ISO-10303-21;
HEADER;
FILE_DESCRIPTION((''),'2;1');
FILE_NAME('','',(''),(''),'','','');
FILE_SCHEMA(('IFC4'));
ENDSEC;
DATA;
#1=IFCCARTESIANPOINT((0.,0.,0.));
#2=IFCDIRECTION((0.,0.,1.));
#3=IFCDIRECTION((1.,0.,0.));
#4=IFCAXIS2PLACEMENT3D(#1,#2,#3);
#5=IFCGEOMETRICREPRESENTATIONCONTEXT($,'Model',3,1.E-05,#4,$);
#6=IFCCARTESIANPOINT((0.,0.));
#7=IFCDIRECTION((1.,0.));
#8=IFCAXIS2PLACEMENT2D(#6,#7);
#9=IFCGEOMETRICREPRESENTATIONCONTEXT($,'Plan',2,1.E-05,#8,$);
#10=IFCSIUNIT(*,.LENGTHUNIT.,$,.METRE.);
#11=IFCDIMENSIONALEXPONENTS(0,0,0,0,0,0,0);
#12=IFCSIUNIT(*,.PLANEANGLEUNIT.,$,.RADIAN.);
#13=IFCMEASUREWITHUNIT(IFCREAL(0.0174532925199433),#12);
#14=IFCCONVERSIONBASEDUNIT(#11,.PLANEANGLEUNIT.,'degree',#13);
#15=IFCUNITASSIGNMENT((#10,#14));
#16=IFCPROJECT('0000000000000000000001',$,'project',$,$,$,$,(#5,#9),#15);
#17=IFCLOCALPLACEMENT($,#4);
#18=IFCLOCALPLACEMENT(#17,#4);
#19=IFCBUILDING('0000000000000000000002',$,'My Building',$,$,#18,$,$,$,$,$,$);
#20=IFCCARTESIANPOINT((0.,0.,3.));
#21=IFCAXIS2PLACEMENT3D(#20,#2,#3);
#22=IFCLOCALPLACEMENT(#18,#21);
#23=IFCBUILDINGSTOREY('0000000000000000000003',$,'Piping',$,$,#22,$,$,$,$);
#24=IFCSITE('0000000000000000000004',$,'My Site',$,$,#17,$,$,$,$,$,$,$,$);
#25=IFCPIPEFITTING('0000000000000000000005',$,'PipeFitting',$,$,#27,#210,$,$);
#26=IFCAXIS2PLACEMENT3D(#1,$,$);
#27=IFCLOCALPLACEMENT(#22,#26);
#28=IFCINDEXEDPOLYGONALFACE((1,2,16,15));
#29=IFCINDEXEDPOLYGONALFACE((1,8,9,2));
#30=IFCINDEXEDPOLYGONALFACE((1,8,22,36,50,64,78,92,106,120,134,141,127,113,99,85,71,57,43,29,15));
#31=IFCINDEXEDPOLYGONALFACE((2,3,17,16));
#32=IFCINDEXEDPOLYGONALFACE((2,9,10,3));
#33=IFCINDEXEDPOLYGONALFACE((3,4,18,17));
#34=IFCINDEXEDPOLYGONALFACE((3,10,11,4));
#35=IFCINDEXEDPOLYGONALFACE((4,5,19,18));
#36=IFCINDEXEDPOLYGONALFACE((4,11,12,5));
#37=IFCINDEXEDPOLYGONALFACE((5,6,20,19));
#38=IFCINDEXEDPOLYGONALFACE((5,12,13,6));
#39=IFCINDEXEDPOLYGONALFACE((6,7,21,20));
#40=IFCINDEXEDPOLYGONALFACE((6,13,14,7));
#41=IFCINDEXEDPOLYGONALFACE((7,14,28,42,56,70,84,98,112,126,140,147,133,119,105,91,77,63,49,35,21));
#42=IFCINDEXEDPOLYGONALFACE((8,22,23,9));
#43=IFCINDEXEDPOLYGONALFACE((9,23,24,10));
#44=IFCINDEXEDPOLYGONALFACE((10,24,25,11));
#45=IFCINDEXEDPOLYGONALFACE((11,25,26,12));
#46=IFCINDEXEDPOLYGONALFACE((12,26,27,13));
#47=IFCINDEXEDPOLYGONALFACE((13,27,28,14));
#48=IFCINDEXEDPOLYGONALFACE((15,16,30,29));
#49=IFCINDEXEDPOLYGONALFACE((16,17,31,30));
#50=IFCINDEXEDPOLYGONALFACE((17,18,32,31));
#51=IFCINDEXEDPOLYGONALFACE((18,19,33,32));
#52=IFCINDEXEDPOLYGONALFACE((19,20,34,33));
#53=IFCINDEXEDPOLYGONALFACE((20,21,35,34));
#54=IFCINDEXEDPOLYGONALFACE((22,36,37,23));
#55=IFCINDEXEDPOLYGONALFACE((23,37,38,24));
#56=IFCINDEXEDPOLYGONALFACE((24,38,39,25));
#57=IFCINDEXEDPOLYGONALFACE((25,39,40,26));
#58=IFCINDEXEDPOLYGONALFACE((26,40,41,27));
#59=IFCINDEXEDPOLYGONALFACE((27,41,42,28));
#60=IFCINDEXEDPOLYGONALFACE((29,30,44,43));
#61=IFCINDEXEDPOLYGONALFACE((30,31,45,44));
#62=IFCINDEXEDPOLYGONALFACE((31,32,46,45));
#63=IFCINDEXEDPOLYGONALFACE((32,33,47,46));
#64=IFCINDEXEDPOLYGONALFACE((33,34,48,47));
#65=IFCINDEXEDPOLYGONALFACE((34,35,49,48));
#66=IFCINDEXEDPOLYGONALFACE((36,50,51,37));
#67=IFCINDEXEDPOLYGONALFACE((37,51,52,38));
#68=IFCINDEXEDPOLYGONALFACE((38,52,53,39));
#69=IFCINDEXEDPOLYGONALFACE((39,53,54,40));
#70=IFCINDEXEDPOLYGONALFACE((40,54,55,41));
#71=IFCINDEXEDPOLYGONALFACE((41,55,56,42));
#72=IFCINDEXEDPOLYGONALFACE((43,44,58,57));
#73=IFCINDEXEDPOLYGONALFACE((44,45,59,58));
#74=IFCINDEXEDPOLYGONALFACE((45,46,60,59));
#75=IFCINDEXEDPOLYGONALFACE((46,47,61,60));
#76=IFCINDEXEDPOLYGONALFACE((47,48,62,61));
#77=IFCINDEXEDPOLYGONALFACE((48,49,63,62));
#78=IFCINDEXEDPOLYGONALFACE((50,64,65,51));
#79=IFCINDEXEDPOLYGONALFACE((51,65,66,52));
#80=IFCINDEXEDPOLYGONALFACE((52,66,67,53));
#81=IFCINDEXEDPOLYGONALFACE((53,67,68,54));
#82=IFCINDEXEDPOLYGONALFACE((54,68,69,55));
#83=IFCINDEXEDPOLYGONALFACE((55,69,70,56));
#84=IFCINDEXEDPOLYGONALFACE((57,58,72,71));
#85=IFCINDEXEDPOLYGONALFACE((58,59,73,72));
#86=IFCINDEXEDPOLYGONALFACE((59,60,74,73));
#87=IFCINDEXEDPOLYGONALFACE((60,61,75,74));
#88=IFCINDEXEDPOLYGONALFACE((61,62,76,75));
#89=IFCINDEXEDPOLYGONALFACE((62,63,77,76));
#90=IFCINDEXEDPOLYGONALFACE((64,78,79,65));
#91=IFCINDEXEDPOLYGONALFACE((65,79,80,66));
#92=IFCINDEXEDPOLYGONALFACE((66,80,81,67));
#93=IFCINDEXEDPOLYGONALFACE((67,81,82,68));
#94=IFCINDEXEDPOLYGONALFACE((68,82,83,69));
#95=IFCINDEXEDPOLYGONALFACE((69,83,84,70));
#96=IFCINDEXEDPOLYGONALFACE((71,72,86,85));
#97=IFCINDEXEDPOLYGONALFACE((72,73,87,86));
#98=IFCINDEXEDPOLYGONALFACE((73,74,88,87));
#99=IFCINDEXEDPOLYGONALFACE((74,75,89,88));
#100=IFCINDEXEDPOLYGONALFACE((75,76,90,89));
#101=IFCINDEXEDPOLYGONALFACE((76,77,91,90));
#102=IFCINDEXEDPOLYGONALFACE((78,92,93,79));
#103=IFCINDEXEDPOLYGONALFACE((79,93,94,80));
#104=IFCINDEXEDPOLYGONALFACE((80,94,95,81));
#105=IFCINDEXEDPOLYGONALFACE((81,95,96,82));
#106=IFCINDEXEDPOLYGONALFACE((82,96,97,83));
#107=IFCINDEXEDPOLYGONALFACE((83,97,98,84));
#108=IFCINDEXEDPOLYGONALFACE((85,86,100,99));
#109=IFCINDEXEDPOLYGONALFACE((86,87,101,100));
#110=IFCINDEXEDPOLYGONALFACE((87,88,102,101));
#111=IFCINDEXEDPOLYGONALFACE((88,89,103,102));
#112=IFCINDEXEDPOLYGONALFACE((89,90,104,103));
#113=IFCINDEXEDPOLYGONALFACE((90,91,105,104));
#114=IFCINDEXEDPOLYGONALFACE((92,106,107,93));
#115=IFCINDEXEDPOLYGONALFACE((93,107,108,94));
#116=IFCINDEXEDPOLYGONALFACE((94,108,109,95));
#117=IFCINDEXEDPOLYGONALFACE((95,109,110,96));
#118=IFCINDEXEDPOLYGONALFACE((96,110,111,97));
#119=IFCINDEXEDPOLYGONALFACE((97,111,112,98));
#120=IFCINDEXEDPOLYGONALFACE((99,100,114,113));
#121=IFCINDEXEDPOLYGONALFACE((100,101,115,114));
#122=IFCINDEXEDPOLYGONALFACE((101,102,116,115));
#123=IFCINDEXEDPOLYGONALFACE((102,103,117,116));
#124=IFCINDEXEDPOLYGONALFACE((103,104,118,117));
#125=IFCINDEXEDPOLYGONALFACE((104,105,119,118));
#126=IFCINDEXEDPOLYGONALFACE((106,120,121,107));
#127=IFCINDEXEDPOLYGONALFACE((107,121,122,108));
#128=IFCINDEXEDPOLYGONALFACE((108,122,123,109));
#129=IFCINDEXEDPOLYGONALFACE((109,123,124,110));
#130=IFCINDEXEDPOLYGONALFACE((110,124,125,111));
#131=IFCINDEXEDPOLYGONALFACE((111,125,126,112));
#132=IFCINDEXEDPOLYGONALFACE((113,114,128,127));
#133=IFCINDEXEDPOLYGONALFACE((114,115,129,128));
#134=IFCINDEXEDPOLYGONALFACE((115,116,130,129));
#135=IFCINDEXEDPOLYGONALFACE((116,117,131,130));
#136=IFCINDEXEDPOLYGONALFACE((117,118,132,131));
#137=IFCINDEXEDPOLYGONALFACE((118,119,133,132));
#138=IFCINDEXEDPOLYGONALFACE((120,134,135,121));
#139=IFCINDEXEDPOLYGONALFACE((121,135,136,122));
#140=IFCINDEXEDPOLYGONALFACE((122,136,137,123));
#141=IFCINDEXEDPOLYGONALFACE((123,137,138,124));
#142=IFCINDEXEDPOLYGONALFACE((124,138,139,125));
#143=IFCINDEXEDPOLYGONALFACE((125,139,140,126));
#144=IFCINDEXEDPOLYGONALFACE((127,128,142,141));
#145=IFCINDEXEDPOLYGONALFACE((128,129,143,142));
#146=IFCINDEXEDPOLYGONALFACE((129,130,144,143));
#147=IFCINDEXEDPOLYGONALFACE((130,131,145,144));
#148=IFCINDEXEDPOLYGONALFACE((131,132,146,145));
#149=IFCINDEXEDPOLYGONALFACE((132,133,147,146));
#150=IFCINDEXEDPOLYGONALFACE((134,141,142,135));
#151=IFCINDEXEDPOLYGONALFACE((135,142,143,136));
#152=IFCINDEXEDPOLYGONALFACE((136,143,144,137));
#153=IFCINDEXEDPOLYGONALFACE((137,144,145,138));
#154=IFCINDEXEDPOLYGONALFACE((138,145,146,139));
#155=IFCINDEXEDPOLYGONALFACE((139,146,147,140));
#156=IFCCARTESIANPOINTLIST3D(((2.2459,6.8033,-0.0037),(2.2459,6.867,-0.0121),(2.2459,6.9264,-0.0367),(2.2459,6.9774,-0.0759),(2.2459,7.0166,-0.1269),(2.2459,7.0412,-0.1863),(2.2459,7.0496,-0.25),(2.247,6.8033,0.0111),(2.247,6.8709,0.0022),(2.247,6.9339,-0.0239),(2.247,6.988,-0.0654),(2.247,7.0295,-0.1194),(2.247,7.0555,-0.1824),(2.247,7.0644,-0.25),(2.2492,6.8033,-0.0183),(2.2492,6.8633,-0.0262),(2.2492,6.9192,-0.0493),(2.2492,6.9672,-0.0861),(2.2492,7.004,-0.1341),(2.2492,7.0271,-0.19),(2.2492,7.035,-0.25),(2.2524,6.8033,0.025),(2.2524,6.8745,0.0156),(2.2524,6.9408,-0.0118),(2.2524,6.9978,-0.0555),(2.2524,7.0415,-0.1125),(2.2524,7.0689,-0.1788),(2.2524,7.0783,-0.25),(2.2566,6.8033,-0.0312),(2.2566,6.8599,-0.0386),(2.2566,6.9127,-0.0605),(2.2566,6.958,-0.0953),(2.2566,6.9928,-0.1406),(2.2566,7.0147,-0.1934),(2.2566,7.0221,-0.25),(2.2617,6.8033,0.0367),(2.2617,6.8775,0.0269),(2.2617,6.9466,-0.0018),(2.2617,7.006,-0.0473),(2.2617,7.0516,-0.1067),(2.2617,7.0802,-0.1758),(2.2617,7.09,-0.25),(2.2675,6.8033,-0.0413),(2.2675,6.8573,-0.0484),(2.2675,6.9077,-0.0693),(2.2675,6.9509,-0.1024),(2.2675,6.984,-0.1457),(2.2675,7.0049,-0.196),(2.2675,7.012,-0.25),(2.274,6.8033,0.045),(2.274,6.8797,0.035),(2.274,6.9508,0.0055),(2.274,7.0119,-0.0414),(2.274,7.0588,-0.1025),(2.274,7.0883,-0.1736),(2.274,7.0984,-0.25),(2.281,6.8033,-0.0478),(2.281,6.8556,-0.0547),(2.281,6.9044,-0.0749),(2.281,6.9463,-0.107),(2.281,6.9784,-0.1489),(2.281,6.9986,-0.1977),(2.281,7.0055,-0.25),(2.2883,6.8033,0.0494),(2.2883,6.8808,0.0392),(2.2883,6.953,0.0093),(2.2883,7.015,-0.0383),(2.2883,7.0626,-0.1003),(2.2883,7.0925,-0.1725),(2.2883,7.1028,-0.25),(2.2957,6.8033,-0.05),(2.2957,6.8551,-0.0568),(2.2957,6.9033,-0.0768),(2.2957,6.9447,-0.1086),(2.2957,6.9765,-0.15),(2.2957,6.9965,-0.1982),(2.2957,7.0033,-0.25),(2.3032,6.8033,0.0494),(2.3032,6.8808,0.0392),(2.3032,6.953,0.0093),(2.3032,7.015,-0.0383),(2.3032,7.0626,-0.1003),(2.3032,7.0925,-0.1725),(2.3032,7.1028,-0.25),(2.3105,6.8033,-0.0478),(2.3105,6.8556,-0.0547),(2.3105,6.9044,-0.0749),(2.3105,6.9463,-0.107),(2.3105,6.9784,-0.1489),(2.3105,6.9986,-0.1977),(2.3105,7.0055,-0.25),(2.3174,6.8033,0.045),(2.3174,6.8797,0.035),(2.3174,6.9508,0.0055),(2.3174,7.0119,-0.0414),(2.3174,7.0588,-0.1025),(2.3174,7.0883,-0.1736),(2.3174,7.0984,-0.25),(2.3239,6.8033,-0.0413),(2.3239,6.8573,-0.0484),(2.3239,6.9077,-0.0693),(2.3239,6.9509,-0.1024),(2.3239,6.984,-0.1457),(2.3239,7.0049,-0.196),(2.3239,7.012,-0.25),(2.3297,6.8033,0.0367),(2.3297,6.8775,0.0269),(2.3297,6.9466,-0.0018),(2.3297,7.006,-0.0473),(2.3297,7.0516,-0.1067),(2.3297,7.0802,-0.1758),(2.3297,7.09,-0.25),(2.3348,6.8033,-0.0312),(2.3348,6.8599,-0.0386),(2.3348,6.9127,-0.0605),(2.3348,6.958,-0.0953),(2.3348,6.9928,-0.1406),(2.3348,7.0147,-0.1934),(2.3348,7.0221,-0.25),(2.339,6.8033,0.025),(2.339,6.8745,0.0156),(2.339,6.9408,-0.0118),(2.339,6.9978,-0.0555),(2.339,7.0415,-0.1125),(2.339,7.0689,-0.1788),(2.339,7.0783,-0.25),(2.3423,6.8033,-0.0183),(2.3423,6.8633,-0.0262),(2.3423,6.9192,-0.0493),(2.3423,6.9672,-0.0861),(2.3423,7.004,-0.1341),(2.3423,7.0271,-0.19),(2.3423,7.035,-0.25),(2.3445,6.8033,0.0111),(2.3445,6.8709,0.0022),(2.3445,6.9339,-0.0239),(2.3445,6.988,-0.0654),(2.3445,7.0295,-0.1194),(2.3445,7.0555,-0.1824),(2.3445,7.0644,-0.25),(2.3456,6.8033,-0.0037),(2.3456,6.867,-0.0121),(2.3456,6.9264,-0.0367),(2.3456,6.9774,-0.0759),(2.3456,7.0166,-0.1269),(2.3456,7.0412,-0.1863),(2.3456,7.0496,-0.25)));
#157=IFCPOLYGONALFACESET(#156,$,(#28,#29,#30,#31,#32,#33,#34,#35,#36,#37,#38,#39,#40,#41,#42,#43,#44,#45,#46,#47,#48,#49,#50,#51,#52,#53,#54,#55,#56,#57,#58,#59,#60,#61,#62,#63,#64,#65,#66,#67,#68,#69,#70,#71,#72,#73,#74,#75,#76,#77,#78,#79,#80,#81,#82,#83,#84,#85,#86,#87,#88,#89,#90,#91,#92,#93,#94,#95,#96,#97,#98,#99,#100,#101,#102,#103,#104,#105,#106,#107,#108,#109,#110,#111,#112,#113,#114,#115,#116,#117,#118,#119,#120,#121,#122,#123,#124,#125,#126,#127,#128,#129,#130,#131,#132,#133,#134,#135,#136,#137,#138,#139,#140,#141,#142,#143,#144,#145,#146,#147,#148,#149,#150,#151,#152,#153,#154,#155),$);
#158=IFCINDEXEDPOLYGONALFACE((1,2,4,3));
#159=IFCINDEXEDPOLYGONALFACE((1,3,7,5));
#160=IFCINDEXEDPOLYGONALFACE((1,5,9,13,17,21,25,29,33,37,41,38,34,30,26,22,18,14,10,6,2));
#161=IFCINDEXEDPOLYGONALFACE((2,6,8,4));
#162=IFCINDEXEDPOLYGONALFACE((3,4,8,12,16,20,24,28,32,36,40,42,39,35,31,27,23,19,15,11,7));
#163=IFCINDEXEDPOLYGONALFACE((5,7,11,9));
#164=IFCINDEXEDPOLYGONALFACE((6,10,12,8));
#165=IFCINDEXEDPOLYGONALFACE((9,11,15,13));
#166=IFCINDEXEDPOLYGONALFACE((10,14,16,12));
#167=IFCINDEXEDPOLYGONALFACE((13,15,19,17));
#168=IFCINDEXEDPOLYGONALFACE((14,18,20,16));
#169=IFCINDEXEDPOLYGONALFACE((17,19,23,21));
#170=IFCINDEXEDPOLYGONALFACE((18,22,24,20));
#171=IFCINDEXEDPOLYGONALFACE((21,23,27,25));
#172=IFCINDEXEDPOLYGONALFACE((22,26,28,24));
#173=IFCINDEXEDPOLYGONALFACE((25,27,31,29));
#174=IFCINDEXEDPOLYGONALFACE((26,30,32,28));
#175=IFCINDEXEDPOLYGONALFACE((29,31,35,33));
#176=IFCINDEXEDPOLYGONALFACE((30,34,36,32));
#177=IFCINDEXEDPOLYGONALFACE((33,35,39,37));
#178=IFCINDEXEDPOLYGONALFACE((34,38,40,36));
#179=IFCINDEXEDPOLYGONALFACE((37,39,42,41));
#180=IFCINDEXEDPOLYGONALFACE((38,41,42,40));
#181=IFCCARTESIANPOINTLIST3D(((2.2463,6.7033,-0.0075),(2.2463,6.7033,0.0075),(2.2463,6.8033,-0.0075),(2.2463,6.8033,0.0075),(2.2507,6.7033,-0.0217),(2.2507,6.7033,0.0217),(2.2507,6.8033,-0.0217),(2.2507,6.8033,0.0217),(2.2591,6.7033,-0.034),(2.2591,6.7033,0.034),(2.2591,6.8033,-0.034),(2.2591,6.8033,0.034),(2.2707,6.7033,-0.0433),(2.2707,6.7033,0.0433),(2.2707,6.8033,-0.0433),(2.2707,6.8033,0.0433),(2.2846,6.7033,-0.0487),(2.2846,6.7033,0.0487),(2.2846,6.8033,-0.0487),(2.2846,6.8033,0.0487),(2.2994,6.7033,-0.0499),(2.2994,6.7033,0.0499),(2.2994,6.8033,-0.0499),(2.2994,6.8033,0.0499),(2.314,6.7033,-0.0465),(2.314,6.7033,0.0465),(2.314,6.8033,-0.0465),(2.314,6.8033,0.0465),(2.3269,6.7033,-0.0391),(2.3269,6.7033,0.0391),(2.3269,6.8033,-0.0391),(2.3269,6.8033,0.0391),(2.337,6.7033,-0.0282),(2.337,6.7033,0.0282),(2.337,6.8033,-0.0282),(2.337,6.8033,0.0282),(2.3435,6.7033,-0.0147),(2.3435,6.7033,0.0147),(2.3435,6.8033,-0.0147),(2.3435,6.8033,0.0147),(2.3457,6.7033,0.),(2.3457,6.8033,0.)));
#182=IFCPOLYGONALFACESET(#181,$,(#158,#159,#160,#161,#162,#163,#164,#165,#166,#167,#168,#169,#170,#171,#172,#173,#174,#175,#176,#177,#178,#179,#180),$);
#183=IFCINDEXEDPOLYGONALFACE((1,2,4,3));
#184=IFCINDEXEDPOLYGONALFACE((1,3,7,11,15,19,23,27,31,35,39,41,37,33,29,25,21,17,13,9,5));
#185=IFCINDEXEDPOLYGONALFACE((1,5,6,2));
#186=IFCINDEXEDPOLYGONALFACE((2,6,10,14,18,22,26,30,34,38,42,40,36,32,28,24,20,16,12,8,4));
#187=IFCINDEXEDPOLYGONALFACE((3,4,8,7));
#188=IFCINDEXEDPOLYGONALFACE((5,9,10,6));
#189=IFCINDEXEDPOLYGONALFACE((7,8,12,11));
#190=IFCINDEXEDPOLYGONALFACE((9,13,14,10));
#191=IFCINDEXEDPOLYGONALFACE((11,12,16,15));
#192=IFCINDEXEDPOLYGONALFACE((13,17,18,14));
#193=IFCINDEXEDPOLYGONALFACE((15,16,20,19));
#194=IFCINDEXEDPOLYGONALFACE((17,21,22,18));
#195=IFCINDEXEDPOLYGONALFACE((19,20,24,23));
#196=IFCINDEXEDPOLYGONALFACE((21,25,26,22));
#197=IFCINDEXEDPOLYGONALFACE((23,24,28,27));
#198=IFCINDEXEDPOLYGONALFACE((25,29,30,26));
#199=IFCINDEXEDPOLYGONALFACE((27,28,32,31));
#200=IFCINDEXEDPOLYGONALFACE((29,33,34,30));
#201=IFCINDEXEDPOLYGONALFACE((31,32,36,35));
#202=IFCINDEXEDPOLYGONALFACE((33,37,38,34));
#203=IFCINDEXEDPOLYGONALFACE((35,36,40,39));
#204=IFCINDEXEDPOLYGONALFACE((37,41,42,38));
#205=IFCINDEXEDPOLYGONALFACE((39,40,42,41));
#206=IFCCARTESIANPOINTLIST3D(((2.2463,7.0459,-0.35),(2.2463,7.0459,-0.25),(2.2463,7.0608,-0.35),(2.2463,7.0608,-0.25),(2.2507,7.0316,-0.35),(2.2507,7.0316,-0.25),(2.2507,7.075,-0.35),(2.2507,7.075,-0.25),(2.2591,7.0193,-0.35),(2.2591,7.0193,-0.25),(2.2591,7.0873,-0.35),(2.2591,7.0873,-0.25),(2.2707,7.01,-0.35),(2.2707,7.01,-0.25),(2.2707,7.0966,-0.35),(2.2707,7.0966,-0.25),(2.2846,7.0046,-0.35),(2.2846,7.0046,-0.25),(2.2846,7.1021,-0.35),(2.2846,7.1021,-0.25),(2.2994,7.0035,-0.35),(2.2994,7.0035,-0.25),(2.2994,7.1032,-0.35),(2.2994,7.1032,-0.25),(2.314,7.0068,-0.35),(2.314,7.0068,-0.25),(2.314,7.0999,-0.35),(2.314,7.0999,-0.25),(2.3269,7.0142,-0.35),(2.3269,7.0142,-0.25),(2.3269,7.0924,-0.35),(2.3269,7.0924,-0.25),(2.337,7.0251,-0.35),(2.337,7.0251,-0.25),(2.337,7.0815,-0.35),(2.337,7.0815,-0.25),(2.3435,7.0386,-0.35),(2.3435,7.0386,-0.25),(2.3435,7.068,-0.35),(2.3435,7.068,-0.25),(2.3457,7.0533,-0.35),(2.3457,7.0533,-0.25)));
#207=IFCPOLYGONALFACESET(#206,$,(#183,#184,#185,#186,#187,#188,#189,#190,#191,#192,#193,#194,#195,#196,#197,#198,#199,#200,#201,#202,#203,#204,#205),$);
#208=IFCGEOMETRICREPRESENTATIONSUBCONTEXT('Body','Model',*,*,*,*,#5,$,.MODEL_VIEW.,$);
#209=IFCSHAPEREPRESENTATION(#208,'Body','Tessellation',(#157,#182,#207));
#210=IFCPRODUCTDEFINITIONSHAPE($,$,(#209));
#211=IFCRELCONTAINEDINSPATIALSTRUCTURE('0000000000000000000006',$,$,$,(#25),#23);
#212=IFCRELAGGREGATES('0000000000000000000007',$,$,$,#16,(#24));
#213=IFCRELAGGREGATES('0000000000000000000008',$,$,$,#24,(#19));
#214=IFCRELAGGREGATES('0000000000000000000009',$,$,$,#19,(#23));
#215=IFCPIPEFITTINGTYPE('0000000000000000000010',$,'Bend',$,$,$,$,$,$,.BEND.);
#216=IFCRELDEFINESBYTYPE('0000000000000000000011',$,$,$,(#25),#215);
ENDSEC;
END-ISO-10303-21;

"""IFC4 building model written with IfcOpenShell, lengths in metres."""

from ifc_helpers import new_model, entity, si_unit, converted_unit, frame, origin_with_axes, origin_2d_with_axis, place, context, subcontext, project, spatial, line, indexed_curve, circle, outline, extrude, source, transform, mapped, type_object, type_shapes, element, save


model = new_model("IFC4")

# Units and contexts
model_context = context("Model", 3, precision=1e-05, world=origin_with_axes())
plan_context = context("Plan", 2, precision=1e-05, world=origin_2d_with_axis())
body_context = subcontext(model_context, "Body", "Model", "MODEL_VIEW")
ifc_project = project(units=[si_unit("LENGTHUNIT", "METRE"), converted_unit("PLANEANGLEUNIT", "degree", entity("IfcReal", 0.0174532925199433), si_unit("PLANEANGLEUNIT", "RADIAN"), dimensions=[0, 0, 0, 0, 0, 0, 0])], contexts=[model_context, plan_context])

# Site, building, storey
site_placement = place(None, origin_with_axes())
site = spatial("IfcSite", under=ifc_project, at=site_placement, Name="My Site")
building_placement = place(site_placement, origin_with_axes())
building = spatial("IfcBuilding", under=site, at=building_placement, Name="My Building")
storey_placement = place(building_placement, frame((0.0, 0.0, 3.0), z_axis=(0.0, 0.0, 1.0), x_axis=(1.0, 0.0, 0.0)))
storey = spatial("IfcBuildingStorey", under=building, at=storey_placement, Name="Piping")

# Pipe fitting, opening
pipe_fitting_type = type_object("IfcPipeFittingType", Name="Bend", PredefinedType="BEND")
shared_shape = source(origin_with_axes(), body_context, "Body", "SolidModel", [
    entity("IfcSweptDiskSolid", entity("IfcIndexedPolyCurve", entity("IfcCartesianPointList3D", [[0.0, 0.0, -0.1], [0.0, -0.0732, -0.2768], [0.0, -0.25, -0.35]]), [entity("IfcArcIndex", [1, 2, 3])]), 0.05),
    extrude(circle(Radius=0.05), origin_with_axes(), (0.0, 0.0, -1.0), 0.1),
    extrude(circle(Radius=0.05), frame((0.0, -0.25, -0.35), z_axis=(0.0, -1.0, 0.0), x_axis=(1.0, 0.0, 0.0)), (0.0, 0.0, 1.0), 0.1),
])
type_shapes(pipe_fitting_type, [shared_shape])
pipe_fitting_1_placement = place(storey_placement, frame((2.2957, 6.7033, 0.0), z_axis=(0.0, -1.0, 0.0), x_axis=(1.0, 0.0, 0.0)))
pipe_fitting_1 = element("IfcPipeFitting", 1, at=pipe_fitting_1_placement, inside=storey, type_object=pipe_fitting_type, Name="PipeFitting", context=body_context, shape_type="MappedRepresentation", body=[
    mapped(shared_shape, transform((0.0, 0.0, 0.0), x_axis=(1.0, 0.0, 0.0), y_axis=(0.0, 1.0, 0.0), z_axis=(0.0, 0.0, 1.0), scale=1.0)),
])
opening_1_placement = place(pipe_fitting_1_placement, frame((-2.2957, -3.0, 6.7033), z_axis=(0.0, 1.0, 0.0), x_axis=(1.0, 0.0, 0.0)))
element("IfcOpeningElement", 2, at=opening_1_placement, cuts=pipe_fitting_1, PredefinedType="OPENING", context=body_context, shape_type="SweptSolid", body=[
    extrude(outline(indexed_curve([(0.0, 0.0), (0.5, 0.0), (0.5, 0.5), (0.0, 0.5)], segments=[line(1, 2, 3, 4, 1)])), origin_with_axes(), (0.0, 0.0, 1.0), 0.5),
])

save(model, "model.ifc")
